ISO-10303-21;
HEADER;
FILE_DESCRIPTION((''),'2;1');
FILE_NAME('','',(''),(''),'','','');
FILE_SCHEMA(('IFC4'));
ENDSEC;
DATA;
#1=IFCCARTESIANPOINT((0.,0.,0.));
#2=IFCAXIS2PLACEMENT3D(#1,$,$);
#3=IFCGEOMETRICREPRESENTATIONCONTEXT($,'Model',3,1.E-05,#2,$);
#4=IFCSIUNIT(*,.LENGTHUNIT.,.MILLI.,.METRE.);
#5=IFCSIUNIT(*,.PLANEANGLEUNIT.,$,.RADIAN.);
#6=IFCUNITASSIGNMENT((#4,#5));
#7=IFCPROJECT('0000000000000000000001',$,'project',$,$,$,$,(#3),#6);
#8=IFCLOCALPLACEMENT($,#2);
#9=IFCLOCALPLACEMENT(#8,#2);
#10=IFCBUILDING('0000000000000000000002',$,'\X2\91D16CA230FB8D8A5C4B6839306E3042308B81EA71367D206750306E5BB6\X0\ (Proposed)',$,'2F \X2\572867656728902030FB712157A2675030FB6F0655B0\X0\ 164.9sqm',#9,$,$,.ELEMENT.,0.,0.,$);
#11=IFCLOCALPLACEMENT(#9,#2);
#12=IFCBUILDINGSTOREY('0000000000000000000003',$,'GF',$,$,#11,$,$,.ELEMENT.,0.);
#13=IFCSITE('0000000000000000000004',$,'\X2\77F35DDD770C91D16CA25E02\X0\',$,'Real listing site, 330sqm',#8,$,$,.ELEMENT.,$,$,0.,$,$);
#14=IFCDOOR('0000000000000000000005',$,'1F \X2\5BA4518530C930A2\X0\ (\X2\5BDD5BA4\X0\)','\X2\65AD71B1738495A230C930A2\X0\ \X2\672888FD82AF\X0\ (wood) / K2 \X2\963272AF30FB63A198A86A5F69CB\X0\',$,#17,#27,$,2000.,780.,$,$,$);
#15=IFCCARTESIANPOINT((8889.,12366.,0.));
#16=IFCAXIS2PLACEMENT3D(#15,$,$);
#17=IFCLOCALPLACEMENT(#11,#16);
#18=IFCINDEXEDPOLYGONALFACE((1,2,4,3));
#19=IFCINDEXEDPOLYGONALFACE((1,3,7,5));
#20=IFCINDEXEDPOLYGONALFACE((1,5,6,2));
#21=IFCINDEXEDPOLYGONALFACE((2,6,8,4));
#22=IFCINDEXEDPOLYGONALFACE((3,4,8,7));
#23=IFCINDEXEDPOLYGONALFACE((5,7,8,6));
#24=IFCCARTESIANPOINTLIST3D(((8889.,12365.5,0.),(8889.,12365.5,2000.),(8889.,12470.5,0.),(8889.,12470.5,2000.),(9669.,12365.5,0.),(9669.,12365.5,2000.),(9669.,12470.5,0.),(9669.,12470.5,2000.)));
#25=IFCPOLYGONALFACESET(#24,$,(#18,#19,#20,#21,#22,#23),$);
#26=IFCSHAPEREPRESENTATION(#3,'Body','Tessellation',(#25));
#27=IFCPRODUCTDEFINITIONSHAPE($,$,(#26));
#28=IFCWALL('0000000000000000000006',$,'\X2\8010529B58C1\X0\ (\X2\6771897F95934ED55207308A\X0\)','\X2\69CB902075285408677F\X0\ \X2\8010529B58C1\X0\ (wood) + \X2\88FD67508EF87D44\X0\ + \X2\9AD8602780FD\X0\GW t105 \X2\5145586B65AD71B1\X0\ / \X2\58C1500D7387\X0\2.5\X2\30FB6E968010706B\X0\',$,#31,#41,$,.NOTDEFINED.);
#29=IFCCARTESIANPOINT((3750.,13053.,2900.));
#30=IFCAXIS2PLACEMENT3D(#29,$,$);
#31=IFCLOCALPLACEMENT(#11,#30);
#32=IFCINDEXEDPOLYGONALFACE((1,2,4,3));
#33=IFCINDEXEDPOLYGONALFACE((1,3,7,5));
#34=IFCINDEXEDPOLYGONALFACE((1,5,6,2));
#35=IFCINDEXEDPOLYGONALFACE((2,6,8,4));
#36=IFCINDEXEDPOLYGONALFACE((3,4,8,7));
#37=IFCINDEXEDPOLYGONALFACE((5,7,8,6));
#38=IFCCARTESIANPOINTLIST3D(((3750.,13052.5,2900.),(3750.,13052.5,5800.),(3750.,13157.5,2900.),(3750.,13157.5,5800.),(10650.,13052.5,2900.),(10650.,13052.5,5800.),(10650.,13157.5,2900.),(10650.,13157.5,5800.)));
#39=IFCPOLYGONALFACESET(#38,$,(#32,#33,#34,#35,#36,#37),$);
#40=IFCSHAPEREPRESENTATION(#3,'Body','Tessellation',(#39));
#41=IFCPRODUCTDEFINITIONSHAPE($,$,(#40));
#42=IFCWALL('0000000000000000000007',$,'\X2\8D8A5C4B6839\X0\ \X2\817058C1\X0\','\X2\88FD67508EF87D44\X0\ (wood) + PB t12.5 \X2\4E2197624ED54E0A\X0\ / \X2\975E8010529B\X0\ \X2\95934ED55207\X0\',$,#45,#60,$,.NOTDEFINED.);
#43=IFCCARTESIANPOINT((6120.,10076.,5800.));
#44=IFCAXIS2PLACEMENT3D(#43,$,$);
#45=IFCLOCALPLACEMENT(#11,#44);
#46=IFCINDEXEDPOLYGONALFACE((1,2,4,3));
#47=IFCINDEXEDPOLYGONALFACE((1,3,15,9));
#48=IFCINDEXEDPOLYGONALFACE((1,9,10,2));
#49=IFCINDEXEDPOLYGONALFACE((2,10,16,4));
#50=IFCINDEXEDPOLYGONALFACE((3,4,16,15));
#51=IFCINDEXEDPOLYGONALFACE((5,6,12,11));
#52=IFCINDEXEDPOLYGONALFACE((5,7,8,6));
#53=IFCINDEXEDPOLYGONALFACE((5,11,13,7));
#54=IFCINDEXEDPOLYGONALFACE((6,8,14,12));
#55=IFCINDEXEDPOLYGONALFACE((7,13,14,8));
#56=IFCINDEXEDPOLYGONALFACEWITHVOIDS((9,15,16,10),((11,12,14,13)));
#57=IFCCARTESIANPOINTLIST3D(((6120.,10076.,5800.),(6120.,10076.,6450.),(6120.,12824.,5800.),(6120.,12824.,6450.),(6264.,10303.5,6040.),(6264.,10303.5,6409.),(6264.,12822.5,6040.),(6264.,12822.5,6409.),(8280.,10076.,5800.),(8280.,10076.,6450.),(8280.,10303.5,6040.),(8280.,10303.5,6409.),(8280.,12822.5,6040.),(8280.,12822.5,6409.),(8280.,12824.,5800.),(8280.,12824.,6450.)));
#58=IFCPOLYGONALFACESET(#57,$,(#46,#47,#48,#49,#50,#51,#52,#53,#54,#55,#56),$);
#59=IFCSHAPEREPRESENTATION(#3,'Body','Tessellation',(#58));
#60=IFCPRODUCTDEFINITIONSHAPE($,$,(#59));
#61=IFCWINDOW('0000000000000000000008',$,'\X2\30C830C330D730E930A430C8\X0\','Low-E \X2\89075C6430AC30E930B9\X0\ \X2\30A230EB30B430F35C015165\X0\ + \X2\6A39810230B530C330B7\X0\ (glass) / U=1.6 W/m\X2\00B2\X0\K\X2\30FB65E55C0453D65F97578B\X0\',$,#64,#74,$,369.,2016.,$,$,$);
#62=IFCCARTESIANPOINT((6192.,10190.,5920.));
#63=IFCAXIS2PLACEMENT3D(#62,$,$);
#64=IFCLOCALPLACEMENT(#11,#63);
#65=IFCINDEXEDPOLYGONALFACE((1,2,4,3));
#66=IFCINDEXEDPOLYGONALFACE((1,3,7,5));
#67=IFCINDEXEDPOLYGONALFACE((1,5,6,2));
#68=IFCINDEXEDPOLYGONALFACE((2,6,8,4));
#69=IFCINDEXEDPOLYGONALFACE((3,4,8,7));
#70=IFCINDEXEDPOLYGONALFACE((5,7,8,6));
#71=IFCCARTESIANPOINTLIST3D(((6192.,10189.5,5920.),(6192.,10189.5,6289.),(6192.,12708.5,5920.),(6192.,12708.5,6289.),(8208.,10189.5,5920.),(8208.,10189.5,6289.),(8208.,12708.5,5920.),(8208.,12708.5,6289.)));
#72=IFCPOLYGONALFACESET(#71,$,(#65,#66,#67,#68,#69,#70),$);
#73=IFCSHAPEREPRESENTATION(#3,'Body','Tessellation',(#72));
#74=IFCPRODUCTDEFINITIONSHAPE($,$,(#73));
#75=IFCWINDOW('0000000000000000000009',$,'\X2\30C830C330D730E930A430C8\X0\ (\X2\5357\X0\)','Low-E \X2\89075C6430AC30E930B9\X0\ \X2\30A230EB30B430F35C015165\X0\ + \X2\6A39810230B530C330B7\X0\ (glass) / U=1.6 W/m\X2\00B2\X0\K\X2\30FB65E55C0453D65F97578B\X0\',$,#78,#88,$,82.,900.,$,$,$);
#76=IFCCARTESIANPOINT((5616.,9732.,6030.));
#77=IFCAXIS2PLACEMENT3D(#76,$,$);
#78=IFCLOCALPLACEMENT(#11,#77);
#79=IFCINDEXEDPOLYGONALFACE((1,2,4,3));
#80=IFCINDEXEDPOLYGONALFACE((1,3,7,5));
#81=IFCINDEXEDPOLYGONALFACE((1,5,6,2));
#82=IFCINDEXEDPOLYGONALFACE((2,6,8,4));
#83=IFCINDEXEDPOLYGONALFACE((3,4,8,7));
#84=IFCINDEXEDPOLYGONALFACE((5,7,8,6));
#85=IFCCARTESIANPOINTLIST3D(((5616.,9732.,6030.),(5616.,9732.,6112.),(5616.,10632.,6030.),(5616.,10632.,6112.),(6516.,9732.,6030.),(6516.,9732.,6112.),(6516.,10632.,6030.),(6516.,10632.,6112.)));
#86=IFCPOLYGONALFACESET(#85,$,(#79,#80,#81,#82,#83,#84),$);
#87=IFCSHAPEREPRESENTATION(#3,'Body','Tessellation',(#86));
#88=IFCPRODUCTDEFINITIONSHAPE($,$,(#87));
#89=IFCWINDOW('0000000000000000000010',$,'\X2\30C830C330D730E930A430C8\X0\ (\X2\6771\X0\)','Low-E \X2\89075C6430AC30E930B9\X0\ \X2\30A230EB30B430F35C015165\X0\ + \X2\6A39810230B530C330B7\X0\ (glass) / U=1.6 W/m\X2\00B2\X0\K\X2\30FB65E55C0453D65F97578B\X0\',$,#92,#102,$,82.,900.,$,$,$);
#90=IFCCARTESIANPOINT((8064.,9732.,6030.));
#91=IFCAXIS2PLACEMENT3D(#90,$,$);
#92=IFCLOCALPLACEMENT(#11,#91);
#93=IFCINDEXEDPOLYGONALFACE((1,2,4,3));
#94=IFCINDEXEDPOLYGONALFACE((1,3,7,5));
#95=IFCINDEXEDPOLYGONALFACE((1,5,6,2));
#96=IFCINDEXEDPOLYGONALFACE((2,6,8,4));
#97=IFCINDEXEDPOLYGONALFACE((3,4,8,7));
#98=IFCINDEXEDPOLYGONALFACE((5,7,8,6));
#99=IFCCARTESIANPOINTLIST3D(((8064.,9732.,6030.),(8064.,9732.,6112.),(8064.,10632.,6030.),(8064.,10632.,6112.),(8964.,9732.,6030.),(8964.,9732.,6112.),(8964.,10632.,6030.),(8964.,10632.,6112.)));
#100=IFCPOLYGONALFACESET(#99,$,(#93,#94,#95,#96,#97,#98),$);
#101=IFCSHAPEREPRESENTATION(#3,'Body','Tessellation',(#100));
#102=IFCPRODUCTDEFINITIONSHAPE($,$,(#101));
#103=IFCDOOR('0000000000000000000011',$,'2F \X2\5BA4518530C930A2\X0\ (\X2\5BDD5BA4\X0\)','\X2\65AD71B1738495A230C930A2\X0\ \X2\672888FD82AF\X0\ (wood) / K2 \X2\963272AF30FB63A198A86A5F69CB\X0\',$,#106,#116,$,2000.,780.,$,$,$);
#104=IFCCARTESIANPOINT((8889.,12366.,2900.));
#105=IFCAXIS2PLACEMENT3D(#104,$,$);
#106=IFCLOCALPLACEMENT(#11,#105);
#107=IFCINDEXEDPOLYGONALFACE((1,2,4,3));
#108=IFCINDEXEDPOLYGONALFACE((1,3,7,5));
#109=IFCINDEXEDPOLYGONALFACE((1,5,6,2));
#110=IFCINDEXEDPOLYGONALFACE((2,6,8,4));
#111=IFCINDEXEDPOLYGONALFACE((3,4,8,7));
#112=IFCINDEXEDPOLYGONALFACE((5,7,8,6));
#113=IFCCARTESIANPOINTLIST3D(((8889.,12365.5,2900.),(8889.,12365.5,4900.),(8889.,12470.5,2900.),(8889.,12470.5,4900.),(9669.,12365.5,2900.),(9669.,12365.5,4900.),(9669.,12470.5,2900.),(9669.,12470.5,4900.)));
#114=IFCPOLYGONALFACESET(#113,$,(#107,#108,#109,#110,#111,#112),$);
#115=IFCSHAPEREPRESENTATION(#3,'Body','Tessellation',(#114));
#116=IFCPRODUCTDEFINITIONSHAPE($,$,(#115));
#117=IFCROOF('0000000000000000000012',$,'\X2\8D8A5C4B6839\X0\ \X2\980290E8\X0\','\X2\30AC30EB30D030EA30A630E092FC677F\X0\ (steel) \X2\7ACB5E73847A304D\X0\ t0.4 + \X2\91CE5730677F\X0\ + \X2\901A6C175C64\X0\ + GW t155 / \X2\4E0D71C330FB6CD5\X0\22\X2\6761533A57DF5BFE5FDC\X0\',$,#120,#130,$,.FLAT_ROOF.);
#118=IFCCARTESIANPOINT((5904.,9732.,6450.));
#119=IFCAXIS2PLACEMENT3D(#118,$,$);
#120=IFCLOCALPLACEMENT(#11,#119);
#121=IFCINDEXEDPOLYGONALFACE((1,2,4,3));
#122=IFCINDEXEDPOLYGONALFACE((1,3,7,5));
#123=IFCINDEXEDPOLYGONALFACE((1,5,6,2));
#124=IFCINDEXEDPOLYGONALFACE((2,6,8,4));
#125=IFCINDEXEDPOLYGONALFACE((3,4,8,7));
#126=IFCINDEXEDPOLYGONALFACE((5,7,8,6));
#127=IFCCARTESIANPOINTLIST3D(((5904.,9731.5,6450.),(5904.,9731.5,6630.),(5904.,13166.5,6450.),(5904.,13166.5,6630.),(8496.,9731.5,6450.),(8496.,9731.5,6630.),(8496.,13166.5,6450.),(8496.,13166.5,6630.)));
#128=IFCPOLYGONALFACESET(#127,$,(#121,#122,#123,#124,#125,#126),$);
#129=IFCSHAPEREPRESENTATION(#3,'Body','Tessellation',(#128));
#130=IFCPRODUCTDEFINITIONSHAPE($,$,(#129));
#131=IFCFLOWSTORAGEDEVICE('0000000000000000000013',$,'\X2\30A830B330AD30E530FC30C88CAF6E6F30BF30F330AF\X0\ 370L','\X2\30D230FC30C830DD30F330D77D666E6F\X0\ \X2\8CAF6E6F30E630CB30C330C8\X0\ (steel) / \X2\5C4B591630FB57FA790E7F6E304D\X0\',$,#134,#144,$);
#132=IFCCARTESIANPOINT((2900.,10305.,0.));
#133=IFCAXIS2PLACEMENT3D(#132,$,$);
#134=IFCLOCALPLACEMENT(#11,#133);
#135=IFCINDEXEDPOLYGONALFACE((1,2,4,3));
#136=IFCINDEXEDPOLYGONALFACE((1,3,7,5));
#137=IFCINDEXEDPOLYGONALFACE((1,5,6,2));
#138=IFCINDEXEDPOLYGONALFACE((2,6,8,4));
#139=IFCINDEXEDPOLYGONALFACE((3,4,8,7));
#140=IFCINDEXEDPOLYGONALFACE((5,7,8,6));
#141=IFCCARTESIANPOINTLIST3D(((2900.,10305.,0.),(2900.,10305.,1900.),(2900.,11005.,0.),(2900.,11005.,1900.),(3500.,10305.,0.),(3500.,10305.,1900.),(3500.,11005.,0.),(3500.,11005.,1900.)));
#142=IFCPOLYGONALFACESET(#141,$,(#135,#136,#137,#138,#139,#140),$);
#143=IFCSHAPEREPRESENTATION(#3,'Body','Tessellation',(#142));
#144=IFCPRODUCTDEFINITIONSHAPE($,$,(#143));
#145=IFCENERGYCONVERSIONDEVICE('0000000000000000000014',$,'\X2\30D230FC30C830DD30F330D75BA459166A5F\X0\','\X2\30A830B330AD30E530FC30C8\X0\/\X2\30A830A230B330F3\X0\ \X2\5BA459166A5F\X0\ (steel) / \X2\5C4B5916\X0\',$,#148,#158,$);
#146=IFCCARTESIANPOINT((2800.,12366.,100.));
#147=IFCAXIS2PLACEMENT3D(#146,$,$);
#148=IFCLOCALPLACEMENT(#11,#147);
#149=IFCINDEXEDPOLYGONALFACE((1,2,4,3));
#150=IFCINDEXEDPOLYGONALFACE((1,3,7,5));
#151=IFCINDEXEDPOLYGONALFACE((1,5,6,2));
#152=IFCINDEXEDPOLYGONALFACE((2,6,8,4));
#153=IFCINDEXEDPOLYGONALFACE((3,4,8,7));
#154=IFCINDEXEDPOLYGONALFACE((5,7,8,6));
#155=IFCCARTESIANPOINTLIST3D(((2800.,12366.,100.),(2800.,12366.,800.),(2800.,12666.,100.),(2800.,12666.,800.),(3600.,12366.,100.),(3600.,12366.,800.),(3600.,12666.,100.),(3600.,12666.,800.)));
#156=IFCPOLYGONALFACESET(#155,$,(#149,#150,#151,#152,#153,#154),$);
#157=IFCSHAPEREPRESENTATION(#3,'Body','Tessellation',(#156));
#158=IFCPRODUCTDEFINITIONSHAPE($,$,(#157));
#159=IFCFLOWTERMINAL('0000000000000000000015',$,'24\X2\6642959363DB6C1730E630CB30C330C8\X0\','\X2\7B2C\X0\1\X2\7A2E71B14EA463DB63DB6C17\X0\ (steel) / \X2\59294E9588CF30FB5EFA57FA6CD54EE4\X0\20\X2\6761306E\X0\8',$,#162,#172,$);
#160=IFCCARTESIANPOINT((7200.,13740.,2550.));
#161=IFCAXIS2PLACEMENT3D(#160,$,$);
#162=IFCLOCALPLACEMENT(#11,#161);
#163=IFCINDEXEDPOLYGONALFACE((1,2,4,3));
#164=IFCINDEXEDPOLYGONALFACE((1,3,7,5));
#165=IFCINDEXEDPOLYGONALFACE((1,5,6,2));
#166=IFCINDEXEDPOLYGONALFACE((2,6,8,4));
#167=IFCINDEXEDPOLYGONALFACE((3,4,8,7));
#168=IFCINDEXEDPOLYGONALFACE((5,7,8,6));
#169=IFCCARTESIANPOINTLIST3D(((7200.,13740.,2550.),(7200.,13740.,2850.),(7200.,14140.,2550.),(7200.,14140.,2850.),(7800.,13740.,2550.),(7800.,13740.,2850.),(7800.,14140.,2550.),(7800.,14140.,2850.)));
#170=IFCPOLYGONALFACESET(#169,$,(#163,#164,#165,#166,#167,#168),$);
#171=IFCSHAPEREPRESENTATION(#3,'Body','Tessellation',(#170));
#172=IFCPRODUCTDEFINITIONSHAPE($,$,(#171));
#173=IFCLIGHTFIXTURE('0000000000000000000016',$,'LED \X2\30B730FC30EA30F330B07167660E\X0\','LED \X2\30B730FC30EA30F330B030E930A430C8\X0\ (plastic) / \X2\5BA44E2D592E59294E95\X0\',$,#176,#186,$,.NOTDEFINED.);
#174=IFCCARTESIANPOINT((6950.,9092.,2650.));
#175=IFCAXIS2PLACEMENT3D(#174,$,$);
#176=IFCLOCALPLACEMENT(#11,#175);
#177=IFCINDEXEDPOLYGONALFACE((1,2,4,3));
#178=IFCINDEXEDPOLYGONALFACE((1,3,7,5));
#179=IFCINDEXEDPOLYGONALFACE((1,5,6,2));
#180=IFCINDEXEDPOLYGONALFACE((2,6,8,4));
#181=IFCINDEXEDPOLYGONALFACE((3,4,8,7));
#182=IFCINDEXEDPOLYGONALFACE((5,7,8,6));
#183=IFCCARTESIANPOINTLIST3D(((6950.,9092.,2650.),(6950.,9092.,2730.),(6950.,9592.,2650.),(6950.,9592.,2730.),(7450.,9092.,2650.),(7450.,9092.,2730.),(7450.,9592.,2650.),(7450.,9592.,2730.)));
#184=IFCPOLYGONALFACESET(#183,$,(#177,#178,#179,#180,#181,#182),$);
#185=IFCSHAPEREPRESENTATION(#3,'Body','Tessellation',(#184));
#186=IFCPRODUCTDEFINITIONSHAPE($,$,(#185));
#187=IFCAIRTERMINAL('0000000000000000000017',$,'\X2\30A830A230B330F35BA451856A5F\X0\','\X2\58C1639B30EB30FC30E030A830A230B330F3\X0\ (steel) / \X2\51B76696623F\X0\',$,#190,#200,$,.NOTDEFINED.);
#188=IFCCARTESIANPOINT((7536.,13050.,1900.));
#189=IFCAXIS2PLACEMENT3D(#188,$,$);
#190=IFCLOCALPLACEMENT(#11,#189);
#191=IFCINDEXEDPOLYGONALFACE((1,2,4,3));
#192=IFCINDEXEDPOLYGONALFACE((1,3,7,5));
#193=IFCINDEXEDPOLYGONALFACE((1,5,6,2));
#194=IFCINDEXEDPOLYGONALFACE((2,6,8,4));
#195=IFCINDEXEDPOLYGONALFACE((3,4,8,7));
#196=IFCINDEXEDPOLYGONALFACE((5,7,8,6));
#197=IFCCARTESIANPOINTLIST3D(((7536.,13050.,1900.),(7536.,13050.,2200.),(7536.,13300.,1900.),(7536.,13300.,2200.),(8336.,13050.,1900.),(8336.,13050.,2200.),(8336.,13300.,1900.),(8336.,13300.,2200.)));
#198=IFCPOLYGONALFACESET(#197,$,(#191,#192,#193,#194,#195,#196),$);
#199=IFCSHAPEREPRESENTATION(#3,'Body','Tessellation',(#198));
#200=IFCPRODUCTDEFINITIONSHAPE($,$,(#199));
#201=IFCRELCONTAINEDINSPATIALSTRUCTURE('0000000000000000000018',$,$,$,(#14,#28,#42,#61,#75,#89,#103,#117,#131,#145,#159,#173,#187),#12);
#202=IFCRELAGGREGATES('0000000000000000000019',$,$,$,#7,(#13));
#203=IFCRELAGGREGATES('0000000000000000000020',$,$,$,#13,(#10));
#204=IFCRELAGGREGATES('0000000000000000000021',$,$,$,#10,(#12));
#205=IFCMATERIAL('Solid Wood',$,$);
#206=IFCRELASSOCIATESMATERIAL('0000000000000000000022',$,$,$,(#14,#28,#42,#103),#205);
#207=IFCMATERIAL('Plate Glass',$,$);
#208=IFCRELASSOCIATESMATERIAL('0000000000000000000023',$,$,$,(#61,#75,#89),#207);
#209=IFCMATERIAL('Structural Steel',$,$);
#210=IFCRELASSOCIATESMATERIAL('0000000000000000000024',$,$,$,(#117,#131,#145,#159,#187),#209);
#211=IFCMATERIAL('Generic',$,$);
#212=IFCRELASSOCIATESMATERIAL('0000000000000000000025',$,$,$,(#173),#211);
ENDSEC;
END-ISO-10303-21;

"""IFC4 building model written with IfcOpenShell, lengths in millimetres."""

from ifc_helpers import new_model, si_unit, frame, frame_2d, origin, place, context, project, spatial, rectangle, extrude, material, element, fill, save


model = new_model("IFC4")

# Units and contexts
model_context = context("Model", 3, precision=1e-05, world=origin())
ifc_project = project(units=[si_unit("LENGTHUNIT", "METRE", prefix="MILLI"), si_unit("PLANEANGLEUNIT", "RADIAN")], contexts=[model_context])

# Site, building, storey
site_placement = place(None, origin())
site = spatial("IfcSite", under=ifc_project, at=site_placement, Name="石川県金沢市", ObjectType="Real listing site, 330sqm", CompositionType="ELEMENT", RefElevation=0.0)
building_placement = place(site_placement, origin())
building = spatial("IfcBuilding", under=site, at=building_placement, Name="金沢・越屋根のある自然素材の家 (Proposed)", ObjectType="2F 在来木造・無垢材・漆喰 164.9sqm", CompositionType="ELEMENT", ElevationOfRefHeight=0.0, ElevationOfTerrain=0.0)
storey_placement = place(building_placement, origin())
storey = spatial("IfcBuildingStorey", under=building, at=storey_placement, Name="GF", CompositionType="ELEMENT", Elevation=0.0)

# Shared definitions
ifc_material_1 = material(Name="Solid Wood")

# Door
door_1_placement = place(storey_placement, frame((8889.0, 12366.0, 0.0)))
element("IfcDoor", 1, at=door_1_placement, inside=storey, material=ifc_material_1, Name="1F 室内ドア (寝室)", Description="断熱玄関ドア 木製芯 (wood) / K2 防犯・採風機構", OverallHeight=2000.0, OverallWidth=780.0, context=model_context, shape_type="SweptSolid", body=[
    extrude(rectangle(XDim=780.0, YDim=105.0, at=frame_2d((390.0, 52.0))), frame((8889.0, 12366.0, 0.0)), (0.0, 0.0, 1.0), 2000.0),
])

# Wall
wall_1_placement = place(storey_placement, frame((3750.0, 13053.0, 2900.0)))
element("IfcWall", 2, at=wall_1_placement, inside=storey, material=ifc_material_1, Name="耐力壁 (東西間仕切り)", Description="構造用合板 耐力壁 (wood) + 製材軸組 + 高性能GW t105 充填断熱 / 壁倍率2.5・準耐火", PredefinedType="NOTDEFINED", context=model_context, shape_type="SweptSolid", body=[
    extrude(rectangle(XDim=6900.0, YDim=105.0, at=frame_2d((3450.0, 52.0))), frame((3750.0, 13053.0, 2900.0)), (0.0, 0.0, 1.0), 2900.0),
])

# Wall, openings, windows
wall_2_placement = place(storey_placement, frame((6120.0, 10076.0, 5800.0)))
wall_2 = element("IfcWall", 3, at=wall_2_placement, inside=storey, material=ifc_material_1, Name="越屋根 腰壁", Description="製材軸組 (wood) + PB t12.5 両面仕上 / 非耐力 間仕切", PredefinedType="NOTDEFINED", context=model_context, shape_type="SweptSolid", body=[
    extrude(rectangle(XDim=2160.0, YDim=2748.0, at=frame_2d((1080.0, 1374.0))), frame((6120.0, 10076.0, 5800.0)), (0.0, 0.0, 1.0), 650.0),
])
opening_1_placement = place(storey_placement, frame((6192.0, 10190.0, 5920.0)))
opening_1 = element("IfcOpeningElement", 4, at=opening_1_placement, cuts=wall_2, PredefinedType="NOTDEFINED", context=model_context, shape_type="SweptSolid", body=[
    extrude(rectangle(XDim=2016.0, YDim=2519.0, at=frame_2d((1008.0, 1259.0))), frame((6192.0, 10190.0, 5920.0)), (0.0, 0.0, 1.0), 369.0),
])
opening_2_placement = place(storey_placement, frame((5616.0, 9732.0, 6030.0)))
opening_2 = element("IfcOpeningElement", 5, at=opening_2_placement, cuts=wall_2, PredefinedType="NOTDEFINED", context=model_context, shape_type="SweptSolid", body=[
    extrude(rectangle(XDim=900.0, YDim=900.0, at=frame_2d((450.0, 450.0))), frame((5616.0, 9732.0, 6030.0)), (0.0, 0.0, 1.0), 82.0),
])
opening_3_placement = place(storey_placement, frame((8064.0, 9732.0, 6030.0)))
opening_3 = element("IfcOpeningElement", 6, at=opening_3_placement, cuts=wall_2, PredefinedType="NOTDEFINED", context=model_context, shape_type="SweptSolid", body=[
    extrude(rectangle(XDim=900.0, YDim=900.0, at=frame_2d((450.0, 450.0))), frame((8064.0, 9732.0, 6030.0)), (0.0, 0.0, 1.0), 82.0),
])
ifc_material_2 = material(Name="Plate Glass")
window_1_placement = place(storey_placement, frame((6192.0, 10190.0, 5920.0)))
window_1 = element("IfcWindow", 7, at=window_1_placement, inside=storey, material=ifc_material_2, Name="トップライト", Description="Low-E 複層ガラス アルゴン封入 + 樹脂サッシ (glass) / U=1.6 W/m²K・日射取得型", OverallHeight=369.0, OverallWidth=2016.0, context=model_context, shape_type="SweptSolid", body=[
    extrude(rectangle(XDim=2016.0, YDim=2519.0, at=frame_2d((1008.0, 1259.0))), frame((6192.0, 10190.0, 5920.0)), (0.0, 0.0, 1.0), 369.0),
])
fill(opening_1, window_1)
window_2_placement = place(storey_placement, frame((5616.0, 9732.0, 6030.0)))
window_2 = element("IfcWindow", 8, at=window_2_placement, inside=storey, material=ifc_material_2, Name="トップライト (南)", Description="Low-E 複層ガラス アルゴン封入 + 樹脂サッシ (glass) / U=1.6 W/m²K・日射取得型", OverallHeight=82.0, OverallWidth=900.0, context=model_context, shape_type="SweptSolid", body=[
    extrude(rectangle(XDim=900.0, YDim=900.0, at=frame_2d((450.0, 450.0))), frame((5616.0, 9732.0, 6030.0)), (0.0, 0.0, 1.0), 82.0),
])
fill(opening_2, window_2)
window_3_placement = place(storey_placement, frame((8064.0, 9732.0, 6030.0)))
window_3 = element("IfcWindow", 9, at=window_3_placement, inside=storey, material=ifc_material_2, Name="トップライト (東)", Description="Low-E 複層ガラス アルゴン封入 + 樹脂サッシ (glass) / U=1.6 W/m²K・日射取得型", OverallHeight=82.0, OverallWidth=900.0, context=model_context, shape_type="SweptSolid", body=[
    extrude(rectangle(XDim=900.0, YDim=900.0, at=frame_2d((450.0, 450.0))), frame((8064.0, 9732.0, 6030.0)), (0.0, 0.0, 1.0), 82.0),
])
fill(opening_3, window_3)

# Door
door_2_placement = place(storey_placement, frame((8889.0, 12366.0, 2900.0)))
element("IfcDoor", 10, at=door_2_placement, inside=storey, material=ifc_material_1, Name="2F 室内ドア (寝室)", Description="断熱玄関ドア 木製芯 (wood) / K2 防犯・採風機構", OverallHeight=2000.0, OverallWidth=780.0, context=model_context, shape_type="SweptSolid", body=[
    extrude(rectangle(XDim=780.0, YDim=105.0, at=frame_2d((390.0, 52.0))), frame((8889.0, 12366.0, 2900.0)), (0.0, 0.0, 1.0), 2000.0),
])

# Roof
ifc_material_3 = material(Name="Structural Steel")
roof_placement = place(storey_placement, frame((5904.0, 9732.0, 6450.0)))
element("IfcRoof", 11, at=roof_placement, inside=storey, material=ifc_material_3, Name="越屋根 頂部", Description="ガルバリウム鋼板 (steel) 立平葺き t0.4 + 野地板 + 通気層 + GW t155 / 不燃・法22条区域対応", PredefinedType="FLAT_ROOF", context=model_context, shape_type="SweptSolid", body=[
    extrude(rectangle(XDim=2592.0, YDim=3435.0, at=frame_2d((1296.0, 1717.0))), frame((5904.0, 9732.0, 6450.0)), (0.0, 0.0, 1.0), 180.0),
])

# Flow storage device
flow_storage_device_placement = place(storey_placement, frame((2900.0, 10305.0, 0.0)))
element("IfcFlowStorageDevice", 12, at=flow_storage_device_placement, inside=storey, material=ifc_material_3, Name="エコキュート貯湯タンク 370L", Description="ヒートポンプ給湯 貯湯ユニット (steel) / 屋外・基礎置き", context=model_context, shape_type="SweptSolid", body=[
    extrude(rectangle(XDim=600.0, YDim=700.0, at=frame_2d((300.0, 350.0))), frame((2900.0, 10305.0, 0.0)), (0.0, 0.0, 1.0), 1900.0),
])

# Energy conversion device
energy_conversion_device_placement = place(storey_placement, frame((2800.0, 12366.0, 100.0)))
element("IfcEnergyConversionDevice", 13, at=energy_conversion_device_placement, inside=storey, material=ifc_material_3, Name="ヒートポンプ室外機", Description="エコキュート/エアコン 室外機 (steel) / 屋外", context=model_context, shape_type="SweptSolid", body=[
    extrude(rectangle(XDim=800.0, YDim=300.0, at=frame_2d((400.0, 150.0))), frame((2800.0, 12366.0, 100.0)), (0.0, 0.0, 1.0), 700.0),
])

# Flow terminal
flow_terminal_placement = place(storey_placement, frame((7200.0, 13740.0, 2550.0)))
element("IfcFlowTerminal", 14, at=flow_terminal_placement, inside=storey, material=ifc_material_3, Name="24時間換気ユニット", Description="第1種熱交換換気 (steel) / 天井裏・建基法令20条の8", context=model_context, shape_type="SweptSolid", body=[
    extrude(rectangle(XDim=600.0, YDim=400.0, at=frame_2d((300.0, 200.0))), frame((7200.0, 13740.0, 2550.0)), (0.0, 0.0, 1.0), 300.0),
])

# Light fixture
ifc_material_4 = material(Name="Generic")
light_fixture_1_placement = place(storey_placement, frame((6950.0, 9092.0, 2650.0)))
element("IfcLightFixture", 15, at=light_fixture_1_placement, inside=storey, material=ifc_material_4, Name="LED シーリング照明", Description="LED シーリングライト (plastic) / 室中央天井", PredefinedType="NOTDEFINED", context=model_context, shape_type="SweptSolid", body=[
    extrude(rectangle(XDim=500.0, YDim=500.0, at=frame_2d((250.0, 250.0))), frame((6950.0, 9092.0, 2650.0)), (0.0, 0.0, 1.0), 80.0),
])

# Air terminal
air_terminal_placement = place(storey_placement, frame((7536.0, 13050.0, 1900.0)))
element("IfcAirTerminal", 16, at=air_terminal_placement, inside=storey, material=ifc_material_3, Name="エアコン室内機", Description="壁掛ルームエアコン (steel) / 冷暖房", PredefinedType="NOTDEFINED", context=model_context, shape_type="SweptSolid", body=[
    extrude(rectangle(XDim=800.0, YDim=250.0, at=frame_2d((400.0, 125.0))), frame((7536.0, 13050.0, 1900.0)), (0.0, 0.0, 1.0), 300.0),
])

save(model, "model.ifc")
